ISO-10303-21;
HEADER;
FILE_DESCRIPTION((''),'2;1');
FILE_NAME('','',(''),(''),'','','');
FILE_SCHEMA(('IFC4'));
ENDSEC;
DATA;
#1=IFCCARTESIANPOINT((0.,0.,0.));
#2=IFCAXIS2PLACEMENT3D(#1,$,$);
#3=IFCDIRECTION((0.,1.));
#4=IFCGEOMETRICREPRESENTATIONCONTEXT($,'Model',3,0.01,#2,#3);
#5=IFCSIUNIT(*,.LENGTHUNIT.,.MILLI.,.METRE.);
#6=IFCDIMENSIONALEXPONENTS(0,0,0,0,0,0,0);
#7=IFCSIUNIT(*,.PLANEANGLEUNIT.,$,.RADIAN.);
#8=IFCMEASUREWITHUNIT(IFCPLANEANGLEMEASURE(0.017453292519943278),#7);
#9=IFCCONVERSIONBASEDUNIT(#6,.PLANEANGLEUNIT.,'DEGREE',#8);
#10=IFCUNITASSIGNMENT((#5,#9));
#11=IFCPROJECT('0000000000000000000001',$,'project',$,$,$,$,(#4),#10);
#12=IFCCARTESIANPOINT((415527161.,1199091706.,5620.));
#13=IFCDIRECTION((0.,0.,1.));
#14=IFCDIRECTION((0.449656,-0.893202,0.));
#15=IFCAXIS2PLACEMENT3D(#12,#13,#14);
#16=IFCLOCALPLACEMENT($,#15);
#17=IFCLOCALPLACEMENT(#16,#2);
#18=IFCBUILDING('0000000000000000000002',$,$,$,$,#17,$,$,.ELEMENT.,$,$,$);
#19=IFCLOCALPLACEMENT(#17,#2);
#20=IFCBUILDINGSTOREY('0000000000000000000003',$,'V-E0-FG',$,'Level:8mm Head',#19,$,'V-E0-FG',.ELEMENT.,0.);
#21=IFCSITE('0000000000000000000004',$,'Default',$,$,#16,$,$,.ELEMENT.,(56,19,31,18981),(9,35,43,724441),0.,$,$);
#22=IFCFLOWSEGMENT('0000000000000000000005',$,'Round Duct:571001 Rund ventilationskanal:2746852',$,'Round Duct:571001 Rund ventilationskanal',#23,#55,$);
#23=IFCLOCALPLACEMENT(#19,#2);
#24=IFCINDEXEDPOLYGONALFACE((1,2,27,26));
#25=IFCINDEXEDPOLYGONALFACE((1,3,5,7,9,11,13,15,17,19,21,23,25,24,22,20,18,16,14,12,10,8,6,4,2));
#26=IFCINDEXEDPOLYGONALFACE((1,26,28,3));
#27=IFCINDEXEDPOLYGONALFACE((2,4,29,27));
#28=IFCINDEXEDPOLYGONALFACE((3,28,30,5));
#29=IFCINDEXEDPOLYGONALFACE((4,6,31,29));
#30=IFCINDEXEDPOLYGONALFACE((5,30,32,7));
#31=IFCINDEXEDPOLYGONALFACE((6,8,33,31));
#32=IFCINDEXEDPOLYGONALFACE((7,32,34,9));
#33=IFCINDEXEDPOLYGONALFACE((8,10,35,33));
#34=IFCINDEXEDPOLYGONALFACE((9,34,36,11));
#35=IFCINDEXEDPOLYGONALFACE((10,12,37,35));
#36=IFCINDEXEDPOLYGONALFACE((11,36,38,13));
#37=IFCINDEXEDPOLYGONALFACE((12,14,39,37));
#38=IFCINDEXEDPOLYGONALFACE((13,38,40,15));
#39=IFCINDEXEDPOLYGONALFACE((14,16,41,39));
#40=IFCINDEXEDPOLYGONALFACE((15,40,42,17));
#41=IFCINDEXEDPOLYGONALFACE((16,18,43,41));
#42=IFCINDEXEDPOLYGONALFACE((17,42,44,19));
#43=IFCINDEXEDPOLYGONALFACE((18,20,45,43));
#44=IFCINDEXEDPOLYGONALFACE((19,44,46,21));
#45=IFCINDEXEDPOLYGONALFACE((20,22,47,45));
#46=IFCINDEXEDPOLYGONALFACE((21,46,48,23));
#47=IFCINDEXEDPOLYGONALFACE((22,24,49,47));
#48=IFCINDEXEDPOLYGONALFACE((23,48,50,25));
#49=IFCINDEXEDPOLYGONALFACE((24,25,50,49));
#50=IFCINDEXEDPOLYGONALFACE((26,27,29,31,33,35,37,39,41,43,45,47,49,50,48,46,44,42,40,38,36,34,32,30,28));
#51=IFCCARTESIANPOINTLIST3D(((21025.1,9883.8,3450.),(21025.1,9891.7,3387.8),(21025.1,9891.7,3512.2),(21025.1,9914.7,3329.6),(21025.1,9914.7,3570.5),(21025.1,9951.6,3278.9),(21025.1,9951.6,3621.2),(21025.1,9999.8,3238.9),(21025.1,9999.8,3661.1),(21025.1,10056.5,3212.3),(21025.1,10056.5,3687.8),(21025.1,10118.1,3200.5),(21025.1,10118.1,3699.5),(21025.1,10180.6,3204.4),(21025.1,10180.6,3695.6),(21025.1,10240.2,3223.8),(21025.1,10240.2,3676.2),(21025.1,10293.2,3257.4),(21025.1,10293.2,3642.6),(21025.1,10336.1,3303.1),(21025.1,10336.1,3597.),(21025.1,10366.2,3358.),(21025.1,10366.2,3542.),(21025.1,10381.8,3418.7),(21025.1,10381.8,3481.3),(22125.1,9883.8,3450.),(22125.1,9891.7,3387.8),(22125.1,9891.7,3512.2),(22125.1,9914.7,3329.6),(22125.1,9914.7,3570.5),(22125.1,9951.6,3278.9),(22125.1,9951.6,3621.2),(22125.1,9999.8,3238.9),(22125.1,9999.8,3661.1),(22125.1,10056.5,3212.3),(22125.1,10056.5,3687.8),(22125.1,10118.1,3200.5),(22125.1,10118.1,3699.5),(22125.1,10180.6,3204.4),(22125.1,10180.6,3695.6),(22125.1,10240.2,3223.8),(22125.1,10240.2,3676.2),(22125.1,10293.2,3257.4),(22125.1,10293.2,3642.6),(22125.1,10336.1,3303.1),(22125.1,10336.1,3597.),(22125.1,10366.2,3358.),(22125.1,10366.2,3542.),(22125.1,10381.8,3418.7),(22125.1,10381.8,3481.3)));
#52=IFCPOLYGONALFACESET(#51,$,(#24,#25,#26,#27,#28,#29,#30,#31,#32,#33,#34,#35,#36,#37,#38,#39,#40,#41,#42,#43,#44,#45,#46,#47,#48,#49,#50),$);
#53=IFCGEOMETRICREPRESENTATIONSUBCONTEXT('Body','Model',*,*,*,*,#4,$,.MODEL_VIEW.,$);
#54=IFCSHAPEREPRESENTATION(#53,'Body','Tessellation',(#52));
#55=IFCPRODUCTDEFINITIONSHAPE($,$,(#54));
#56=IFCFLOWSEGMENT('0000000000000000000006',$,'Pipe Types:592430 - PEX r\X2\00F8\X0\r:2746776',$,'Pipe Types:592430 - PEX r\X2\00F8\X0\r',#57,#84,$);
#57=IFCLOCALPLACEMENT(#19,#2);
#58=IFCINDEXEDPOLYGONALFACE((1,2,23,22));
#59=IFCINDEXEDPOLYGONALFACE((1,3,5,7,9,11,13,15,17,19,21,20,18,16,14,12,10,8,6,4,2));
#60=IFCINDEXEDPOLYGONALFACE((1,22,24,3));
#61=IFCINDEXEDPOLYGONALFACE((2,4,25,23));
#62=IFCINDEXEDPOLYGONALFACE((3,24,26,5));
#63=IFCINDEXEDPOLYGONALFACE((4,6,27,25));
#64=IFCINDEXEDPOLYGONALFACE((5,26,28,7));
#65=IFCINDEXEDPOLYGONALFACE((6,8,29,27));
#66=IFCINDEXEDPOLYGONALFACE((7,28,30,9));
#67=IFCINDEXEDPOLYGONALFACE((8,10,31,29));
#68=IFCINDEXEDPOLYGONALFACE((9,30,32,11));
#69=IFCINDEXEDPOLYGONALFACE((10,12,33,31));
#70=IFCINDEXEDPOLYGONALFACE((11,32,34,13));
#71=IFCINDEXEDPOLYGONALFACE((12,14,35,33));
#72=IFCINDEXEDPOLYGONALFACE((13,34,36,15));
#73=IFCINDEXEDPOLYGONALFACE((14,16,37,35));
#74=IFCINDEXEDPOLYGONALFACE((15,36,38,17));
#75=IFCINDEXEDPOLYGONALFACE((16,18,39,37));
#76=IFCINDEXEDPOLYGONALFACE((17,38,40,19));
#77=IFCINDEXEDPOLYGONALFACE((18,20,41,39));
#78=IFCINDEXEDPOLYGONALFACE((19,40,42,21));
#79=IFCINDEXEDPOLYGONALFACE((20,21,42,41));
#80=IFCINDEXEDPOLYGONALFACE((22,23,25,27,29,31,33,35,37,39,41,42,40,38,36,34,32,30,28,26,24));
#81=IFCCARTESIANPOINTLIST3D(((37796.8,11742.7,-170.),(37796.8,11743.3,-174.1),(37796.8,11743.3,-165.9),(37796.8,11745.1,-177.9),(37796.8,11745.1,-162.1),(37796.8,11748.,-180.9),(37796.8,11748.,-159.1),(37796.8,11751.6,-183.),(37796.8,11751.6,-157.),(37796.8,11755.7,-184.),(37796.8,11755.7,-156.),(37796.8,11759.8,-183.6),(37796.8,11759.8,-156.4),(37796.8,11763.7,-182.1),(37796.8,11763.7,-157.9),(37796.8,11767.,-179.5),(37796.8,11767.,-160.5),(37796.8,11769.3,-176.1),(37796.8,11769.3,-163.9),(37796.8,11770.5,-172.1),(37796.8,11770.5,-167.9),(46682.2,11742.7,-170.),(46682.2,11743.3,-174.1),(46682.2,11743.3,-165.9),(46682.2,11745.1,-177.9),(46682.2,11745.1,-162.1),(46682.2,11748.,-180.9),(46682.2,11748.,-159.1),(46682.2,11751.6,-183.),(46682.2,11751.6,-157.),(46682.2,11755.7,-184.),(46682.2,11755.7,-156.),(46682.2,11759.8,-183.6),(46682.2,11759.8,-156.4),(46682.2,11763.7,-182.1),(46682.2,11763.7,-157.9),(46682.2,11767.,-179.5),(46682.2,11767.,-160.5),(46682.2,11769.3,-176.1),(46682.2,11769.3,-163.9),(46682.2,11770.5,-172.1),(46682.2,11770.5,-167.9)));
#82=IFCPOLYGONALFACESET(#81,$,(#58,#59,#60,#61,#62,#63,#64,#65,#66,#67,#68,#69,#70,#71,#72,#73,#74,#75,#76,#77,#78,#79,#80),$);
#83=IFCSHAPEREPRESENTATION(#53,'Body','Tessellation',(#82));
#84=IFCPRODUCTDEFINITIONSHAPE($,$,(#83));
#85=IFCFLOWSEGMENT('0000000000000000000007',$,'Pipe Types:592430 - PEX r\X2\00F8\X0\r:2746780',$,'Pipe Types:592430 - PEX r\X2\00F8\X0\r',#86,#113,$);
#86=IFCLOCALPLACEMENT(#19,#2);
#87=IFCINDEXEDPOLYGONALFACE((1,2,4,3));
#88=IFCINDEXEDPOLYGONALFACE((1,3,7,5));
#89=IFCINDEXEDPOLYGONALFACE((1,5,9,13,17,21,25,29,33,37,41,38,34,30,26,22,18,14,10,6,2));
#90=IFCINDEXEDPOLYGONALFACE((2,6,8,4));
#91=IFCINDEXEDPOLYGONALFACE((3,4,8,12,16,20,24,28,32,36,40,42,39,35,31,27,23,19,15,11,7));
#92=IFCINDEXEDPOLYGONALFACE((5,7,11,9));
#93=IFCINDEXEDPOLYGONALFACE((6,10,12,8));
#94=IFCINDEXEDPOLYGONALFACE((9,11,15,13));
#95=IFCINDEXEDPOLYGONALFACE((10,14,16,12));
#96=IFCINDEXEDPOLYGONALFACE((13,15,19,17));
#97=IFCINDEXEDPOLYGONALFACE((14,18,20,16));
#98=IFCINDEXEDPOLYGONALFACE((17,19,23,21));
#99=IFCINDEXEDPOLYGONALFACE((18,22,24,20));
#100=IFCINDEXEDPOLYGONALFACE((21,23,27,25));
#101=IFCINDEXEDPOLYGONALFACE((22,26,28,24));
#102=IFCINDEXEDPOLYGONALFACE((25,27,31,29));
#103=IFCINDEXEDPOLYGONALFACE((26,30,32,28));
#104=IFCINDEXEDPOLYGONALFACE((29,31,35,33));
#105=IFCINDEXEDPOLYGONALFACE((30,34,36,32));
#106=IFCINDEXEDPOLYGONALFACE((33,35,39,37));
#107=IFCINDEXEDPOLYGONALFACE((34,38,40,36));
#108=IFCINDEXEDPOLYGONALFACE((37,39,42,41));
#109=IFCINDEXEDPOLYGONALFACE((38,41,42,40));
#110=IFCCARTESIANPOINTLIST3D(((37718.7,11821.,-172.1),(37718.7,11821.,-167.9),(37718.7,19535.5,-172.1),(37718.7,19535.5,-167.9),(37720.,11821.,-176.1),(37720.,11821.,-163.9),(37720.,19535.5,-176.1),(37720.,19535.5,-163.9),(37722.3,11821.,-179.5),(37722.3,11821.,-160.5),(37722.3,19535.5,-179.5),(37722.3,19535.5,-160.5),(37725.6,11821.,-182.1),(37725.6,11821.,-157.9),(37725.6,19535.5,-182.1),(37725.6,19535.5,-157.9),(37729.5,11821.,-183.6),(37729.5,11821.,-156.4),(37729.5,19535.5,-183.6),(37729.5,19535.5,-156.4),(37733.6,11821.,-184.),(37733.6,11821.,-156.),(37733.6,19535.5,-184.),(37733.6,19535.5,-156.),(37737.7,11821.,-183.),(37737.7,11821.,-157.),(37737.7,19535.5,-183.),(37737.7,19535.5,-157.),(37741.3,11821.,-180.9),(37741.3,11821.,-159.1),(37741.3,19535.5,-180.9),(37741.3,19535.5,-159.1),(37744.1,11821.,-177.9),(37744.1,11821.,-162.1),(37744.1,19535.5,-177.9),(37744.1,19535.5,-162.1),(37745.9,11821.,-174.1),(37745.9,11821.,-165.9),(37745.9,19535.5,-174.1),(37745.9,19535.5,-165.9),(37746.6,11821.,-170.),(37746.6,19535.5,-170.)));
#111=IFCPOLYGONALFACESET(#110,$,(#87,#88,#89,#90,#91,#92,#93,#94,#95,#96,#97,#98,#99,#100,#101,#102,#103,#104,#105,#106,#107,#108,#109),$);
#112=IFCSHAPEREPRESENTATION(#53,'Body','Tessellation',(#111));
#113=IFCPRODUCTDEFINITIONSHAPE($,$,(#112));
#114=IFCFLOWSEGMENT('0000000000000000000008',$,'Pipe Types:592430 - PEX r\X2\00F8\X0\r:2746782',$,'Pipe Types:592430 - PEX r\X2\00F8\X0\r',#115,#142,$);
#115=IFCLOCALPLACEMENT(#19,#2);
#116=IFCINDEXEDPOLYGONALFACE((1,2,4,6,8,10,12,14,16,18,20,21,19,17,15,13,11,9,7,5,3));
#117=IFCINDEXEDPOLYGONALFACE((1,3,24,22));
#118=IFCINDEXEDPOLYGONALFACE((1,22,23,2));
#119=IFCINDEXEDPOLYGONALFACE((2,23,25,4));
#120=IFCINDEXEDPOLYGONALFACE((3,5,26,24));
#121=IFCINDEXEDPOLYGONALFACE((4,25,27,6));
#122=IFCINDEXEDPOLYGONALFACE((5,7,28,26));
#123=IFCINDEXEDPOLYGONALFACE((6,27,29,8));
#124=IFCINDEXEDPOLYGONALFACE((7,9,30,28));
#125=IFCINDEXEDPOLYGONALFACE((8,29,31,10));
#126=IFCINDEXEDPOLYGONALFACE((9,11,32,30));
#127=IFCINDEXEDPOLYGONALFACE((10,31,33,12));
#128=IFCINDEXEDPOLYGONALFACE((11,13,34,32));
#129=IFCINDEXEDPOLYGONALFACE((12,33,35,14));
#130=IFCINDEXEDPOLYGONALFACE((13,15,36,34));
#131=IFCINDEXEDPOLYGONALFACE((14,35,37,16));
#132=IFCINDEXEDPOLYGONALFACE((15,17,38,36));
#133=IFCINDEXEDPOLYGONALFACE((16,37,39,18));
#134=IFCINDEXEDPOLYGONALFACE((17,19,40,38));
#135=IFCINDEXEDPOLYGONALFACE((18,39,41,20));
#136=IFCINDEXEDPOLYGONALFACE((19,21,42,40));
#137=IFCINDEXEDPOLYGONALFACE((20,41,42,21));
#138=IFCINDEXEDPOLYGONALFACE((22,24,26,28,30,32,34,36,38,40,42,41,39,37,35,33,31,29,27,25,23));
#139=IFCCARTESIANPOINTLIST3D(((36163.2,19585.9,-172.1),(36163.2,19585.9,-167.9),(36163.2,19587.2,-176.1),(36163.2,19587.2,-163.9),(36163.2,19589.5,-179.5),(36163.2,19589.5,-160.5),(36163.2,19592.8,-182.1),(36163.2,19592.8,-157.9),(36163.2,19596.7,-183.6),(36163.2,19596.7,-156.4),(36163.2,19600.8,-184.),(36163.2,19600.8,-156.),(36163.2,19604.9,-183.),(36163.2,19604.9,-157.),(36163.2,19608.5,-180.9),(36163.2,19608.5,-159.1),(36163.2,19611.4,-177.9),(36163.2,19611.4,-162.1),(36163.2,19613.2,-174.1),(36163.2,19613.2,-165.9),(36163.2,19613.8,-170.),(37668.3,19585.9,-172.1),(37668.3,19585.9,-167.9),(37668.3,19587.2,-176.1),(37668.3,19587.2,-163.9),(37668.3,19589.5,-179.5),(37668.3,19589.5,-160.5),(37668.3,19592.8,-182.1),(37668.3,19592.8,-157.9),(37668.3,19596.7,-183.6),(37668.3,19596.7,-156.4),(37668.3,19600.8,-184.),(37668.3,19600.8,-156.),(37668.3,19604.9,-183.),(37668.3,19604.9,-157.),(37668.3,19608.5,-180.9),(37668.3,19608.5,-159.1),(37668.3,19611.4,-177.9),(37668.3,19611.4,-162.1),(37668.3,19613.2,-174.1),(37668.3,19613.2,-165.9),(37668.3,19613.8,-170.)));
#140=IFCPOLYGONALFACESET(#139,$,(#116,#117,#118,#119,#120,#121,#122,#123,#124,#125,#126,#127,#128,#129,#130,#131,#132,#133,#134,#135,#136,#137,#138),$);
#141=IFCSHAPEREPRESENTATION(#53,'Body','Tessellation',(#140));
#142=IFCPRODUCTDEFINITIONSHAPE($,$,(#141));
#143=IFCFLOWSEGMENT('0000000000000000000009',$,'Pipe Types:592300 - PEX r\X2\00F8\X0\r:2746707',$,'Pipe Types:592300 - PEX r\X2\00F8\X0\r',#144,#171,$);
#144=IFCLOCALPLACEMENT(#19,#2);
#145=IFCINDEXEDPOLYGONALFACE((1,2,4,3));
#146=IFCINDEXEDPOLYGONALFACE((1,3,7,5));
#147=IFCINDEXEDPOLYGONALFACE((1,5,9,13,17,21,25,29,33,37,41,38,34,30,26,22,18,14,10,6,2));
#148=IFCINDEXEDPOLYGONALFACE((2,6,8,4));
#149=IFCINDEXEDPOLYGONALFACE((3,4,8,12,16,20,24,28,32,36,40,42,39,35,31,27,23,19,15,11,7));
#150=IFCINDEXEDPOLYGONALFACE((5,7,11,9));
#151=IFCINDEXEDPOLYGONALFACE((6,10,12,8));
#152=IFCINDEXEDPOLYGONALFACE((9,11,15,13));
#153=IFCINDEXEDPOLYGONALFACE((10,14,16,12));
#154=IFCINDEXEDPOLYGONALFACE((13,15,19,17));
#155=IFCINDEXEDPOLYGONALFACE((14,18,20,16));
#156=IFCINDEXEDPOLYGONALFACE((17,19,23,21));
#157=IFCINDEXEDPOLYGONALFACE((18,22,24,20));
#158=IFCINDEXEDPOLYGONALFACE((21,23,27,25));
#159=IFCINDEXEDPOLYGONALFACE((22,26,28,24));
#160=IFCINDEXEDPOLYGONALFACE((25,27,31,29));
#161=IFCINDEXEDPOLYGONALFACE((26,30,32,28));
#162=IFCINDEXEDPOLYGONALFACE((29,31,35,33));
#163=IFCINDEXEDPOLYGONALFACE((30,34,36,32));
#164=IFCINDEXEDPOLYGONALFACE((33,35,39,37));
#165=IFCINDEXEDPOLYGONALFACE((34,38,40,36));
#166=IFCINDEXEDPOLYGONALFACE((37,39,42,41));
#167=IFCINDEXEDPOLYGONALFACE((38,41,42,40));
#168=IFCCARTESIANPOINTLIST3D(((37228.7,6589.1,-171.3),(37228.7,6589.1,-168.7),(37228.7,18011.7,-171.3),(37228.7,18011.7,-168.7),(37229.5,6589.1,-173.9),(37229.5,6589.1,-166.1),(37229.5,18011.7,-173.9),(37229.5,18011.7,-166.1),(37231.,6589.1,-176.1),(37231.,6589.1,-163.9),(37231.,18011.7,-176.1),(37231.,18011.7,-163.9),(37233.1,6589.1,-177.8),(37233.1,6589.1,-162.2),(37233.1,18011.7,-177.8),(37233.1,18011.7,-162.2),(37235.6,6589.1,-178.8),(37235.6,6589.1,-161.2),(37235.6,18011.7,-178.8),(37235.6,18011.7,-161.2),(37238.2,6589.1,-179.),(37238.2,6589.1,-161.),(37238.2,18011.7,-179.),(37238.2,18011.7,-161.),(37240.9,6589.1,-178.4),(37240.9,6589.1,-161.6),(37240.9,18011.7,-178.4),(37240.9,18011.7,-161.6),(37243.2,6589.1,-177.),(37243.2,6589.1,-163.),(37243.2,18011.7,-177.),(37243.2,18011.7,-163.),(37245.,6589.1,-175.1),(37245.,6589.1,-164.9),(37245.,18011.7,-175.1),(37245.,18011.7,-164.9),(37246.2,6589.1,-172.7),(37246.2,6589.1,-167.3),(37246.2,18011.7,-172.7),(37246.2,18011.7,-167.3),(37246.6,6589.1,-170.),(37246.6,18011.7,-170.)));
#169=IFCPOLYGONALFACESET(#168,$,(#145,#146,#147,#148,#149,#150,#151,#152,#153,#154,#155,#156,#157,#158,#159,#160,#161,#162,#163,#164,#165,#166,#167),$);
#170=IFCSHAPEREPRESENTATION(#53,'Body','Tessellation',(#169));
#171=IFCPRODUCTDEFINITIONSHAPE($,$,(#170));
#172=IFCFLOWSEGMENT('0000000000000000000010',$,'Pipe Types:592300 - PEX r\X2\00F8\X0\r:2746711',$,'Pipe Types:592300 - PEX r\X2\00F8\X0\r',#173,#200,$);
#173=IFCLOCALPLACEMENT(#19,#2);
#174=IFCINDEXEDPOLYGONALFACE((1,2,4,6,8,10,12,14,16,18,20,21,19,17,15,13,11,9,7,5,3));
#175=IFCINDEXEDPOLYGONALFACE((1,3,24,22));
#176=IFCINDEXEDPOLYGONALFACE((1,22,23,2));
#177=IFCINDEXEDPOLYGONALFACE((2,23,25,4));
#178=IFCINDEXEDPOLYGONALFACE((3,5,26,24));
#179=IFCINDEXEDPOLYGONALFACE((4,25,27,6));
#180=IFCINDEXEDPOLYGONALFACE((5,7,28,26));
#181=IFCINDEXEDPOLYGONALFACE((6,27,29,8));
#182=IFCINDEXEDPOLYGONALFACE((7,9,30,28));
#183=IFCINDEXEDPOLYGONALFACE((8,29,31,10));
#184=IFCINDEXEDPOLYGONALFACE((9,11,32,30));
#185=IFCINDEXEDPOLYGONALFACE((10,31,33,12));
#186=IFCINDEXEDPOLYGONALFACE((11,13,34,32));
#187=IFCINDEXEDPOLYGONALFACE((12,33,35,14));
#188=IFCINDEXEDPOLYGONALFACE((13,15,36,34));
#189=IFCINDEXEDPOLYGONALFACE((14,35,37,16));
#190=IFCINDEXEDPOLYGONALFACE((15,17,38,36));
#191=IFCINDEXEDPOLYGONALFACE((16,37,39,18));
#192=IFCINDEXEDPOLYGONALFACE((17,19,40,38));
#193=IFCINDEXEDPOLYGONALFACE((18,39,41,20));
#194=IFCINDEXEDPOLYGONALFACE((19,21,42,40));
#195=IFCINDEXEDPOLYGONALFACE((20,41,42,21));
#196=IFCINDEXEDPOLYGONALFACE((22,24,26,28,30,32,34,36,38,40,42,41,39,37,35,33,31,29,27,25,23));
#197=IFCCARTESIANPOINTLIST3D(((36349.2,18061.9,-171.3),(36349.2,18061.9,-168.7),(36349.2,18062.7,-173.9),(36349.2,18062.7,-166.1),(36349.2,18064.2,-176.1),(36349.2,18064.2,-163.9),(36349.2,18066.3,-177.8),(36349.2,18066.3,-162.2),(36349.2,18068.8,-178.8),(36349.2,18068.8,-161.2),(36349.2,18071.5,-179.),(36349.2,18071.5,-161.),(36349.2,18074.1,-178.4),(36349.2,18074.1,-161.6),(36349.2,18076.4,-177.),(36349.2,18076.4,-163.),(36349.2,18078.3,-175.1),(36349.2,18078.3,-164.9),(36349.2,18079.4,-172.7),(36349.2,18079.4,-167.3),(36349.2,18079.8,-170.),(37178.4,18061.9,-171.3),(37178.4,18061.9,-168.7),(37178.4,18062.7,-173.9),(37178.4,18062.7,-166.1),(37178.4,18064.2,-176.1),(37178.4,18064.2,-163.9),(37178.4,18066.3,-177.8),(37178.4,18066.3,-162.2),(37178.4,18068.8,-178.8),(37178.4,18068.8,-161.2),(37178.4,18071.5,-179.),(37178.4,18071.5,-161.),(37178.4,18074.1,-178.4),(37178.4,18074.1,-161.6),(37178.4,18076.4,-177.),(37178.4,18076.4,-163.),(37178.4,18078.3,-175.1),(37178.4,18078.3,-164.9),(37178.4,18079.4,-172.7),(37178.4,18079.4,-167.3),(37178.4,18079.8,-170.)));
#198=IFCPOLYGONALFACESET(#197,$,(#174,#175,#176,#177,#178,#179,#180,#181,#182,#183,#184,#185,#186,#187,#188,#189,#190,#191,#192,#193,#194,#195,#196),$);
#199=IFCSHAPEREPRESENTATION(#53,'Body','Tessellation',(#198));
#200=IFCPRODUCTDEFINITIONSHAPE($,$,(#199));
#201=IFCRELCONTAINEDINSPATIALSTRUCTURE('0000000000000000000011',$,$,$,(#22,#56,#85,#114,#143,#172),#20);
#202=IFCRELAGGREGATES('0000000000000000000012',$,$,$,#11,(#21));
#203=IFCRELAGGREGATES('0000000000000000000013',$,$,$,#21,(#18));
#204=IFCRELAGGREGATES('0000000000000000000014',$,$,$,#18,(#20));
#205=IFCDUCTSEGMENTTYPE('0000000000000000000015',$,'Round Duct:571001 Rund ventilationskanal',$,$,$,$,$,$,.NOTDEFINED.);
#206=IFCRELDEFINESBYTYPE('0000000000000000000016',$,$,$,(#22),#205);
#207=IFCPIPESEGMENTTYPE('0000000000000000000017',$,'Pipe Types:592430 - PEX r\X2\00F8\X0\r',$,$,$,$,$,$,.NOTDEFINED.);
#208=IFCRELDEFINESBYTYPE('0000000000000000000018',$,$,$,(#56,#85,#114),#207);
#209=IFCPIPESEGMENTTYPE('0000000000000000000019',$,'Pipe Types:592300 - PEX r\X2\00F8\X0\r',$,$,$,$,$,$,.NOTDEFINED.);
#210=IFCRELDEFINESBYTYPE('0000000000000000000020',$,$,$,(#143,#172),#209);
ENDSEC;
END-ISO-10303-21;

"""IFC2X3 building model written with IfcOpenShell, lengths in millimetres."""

from ifc_helpers import new_model, entity, si_unit, converted_unit, direction, frame, frame_2d, origin, origin_2d_with_axis, place, context, subcontext, project, spatial, circle, extrude, type_object, element, save


model = new_model("IFC2X3")

# Units and contexts
model_context = context("Model", 3, precision=0.01, world=origin(), true_north=direction((0.0, 1.0)))
body_context = subcontext(model_context, "Body", "Model", "MODEL_VIEW")
ifc_project = project(units=[si_unit("LENGTHUNIT", "METRE", prefix="MILLI"), converted_unit("PLANEANGLEUNIT", "DEGREE", entity("IfcPlaneAngleMeasure", 0.017453292519943278), si_unit("PLANEANGLEUNIT", "RADIAN"), dimensions=[0, 0, 0, 0, 0, 0, 0])], contexts=[model_context])

# Site, building, storey
site_placement = place(None, frame((415527161.0, 1199091706.0, 5620.0), z_axis=(0.0, 0.0, 1.0), x_axis=(0.449656, -0.893202, 0.0)))
site = spatial("IfcSite", under=ifc_project, at=site_placement, Name="Default", CompositionType="ELEMENT", RefLatitude=(56, 19, 31, 18981), RefLongitude=(9, 35, 43, 724441), RefElevation=0.0)
building_placement = place(site_placement, origin())
building = spatial("IfcBuilding", under=site, at=building_placement, CompositionType="ELEMENT")
storey_placement = place(building_placement, origin())
storey = spatial("IfcBuildingStorey", under=building, at=storey_placement, Name="V-E0-FG", ObjectType="Level:8mm Head", LongName="V-E0-FG", CompositionType="ELEMENT", Elevation=0.0)

# Flow segments
duct_segment_type = type_object("IfcDuctSegmentType", Name="Round Duct:571001 Rund ventilationskanal", PredefinedType="NOTDEFINED")
flow_segment_1_placement = place(storey_placement, origin())
element("IfcFlowSegment", 1, at=flow_segment_1_placement, inside=storey, type_object=duct_segment_type, Name="Round Duct:571001 Rund ventilationskanal:2746852", ObjectType="Round Duct:571001 Rund ventilationskanal", context=body_context, shape_type="SweptSolid", body=[
    extrude(circle(Radius=250.0, at=frame_2d((0.0, 0.0), x_axis=(1.0, 0.0))), frame((21025.1, 10133.8, 3450.0), z_axis=(1.0, 0.0, 0.0), x_axis=(0.0, -1.0, 0.0)), (0.0, 0.0, 1.0), 1100.0),
])
pipe_segment_type_1 = type_object("IfcPipeSegmentType", Name="Pipe Types:592430 - PEX rør", PredefinedType="NOTDEFINED")
flow_segment_2_placement = place(storey_placement, origin())
element("IfcFlowSegment", 2, at=flow_segment_2_placement, inside=storey, type_object=pipe_segment_type_1, Name="Pipe Types:592430 - PEX rør:2746776", ObjectType="Pipe Types:592430 - PEX rør", context=body_context, shape_type="SweptSolid", body=[
    extrude(circle(Radius=14.0, at=origin_2d_with_axis()), frame((37796.8, 11756.7, -170.0), z_axis=(1.0, 0.0, 0.0), x_axis=(0.0, -1.0, 0.0)), (0.0, 0.0, 1.0), 8885.3),
])
flow_segment_3_placement = place(storey_placement, origin())
element("IfcFlowSegment", 3, at=flow_segment_3_placement, inside=storey, type_object=pipe_segment_type_1, Name="Pipe Types:592430 - PEX rør:2746780", ObjectType="Pipe Types:592430 - PEX rør", context=body_context, shape_type="SweptSolid", body=[
    extrude(circle(Radius=14.0, at=origin_2d_with_axis()), frame((37732.6, 11821.0, -170.0), z_axis=(0.0, 1.0, 0.0), x_axis=(1.0, 0.0, 0.0)), (0.0, 0.0, 1.0), 7714.5),
])
flow_segment_4_placement = place(storey_placement, origin())
element("IfcFlowSegment", 4, at=flow_segment_4_placement, inside=storey, type_object=pipe_segment_type_1, Name="Pipe Types:592430 - PEX rør:2746782", ObjectType="Pipe Types:592430 - PEX rør", context=body_context, shape_type="SweptSolid", body=[
    extrude(circle(Radius=14.0, at=origin_2d_with_axis()), frame((36163.2, 19599.8, -170.0), z_axis=(1.0, 0.0, 0.0), x_axis=(0.0, 1.0, 0.0)), (0.0, 0.0, 1.0), 1505.1),
])
pipe_segment_type_2 = type_object("IfcPipeSegmentType", Name="Pipe Types:592300 - PEX rør", PredefinedType="NOTDEFINED")
flow_segment_5_placement = place(storey_placement, origin())
element("IfcFlowSegment", 5, at=flow_segment_5_placement, inside=storey, type_object=pipe_segment_type_2, Name="Pipe Types:592300 - PEX rør:2746707", ObjectType="Pipe Types:592300 - PEX rør", context=body_context, shape_type="SweptSolid", body=[
    extrude(circle(Radius=9.0, at=origin_2d_with_axis()), frame((37237.6, 6589.1, -170.0), z_axis=(0.0, 1.0, 0.0), x_axis=(1.0, 0.0, 0.0)), (0.0, 0.0, 1.0), 11422.5),
])
flow_segment_6_placement = place(storey_placement, origin())
element("IfcFlowSegment", 6, at=flow_segment_6_placement, inside=storey, type_object=pipe_segment_type_2, Name="Pipe Types:592300 - PEX rør:2746711", ObjectType="Pipe Types:592300 - PEX rør", context=body_context, shape_type="SweptSolid", body=[
    extrude(circle(Radius=9.0, at=origin_2d_with_axis()), frame((36349.2, 18070.8, -170.0), z_axis=(1.0, 0.0, 0.0), x_axis=(0.0, 1.0, 0.0)), (0.0, 0.0, 1.0), 829.2),
])

save(model, "model.ifc")
